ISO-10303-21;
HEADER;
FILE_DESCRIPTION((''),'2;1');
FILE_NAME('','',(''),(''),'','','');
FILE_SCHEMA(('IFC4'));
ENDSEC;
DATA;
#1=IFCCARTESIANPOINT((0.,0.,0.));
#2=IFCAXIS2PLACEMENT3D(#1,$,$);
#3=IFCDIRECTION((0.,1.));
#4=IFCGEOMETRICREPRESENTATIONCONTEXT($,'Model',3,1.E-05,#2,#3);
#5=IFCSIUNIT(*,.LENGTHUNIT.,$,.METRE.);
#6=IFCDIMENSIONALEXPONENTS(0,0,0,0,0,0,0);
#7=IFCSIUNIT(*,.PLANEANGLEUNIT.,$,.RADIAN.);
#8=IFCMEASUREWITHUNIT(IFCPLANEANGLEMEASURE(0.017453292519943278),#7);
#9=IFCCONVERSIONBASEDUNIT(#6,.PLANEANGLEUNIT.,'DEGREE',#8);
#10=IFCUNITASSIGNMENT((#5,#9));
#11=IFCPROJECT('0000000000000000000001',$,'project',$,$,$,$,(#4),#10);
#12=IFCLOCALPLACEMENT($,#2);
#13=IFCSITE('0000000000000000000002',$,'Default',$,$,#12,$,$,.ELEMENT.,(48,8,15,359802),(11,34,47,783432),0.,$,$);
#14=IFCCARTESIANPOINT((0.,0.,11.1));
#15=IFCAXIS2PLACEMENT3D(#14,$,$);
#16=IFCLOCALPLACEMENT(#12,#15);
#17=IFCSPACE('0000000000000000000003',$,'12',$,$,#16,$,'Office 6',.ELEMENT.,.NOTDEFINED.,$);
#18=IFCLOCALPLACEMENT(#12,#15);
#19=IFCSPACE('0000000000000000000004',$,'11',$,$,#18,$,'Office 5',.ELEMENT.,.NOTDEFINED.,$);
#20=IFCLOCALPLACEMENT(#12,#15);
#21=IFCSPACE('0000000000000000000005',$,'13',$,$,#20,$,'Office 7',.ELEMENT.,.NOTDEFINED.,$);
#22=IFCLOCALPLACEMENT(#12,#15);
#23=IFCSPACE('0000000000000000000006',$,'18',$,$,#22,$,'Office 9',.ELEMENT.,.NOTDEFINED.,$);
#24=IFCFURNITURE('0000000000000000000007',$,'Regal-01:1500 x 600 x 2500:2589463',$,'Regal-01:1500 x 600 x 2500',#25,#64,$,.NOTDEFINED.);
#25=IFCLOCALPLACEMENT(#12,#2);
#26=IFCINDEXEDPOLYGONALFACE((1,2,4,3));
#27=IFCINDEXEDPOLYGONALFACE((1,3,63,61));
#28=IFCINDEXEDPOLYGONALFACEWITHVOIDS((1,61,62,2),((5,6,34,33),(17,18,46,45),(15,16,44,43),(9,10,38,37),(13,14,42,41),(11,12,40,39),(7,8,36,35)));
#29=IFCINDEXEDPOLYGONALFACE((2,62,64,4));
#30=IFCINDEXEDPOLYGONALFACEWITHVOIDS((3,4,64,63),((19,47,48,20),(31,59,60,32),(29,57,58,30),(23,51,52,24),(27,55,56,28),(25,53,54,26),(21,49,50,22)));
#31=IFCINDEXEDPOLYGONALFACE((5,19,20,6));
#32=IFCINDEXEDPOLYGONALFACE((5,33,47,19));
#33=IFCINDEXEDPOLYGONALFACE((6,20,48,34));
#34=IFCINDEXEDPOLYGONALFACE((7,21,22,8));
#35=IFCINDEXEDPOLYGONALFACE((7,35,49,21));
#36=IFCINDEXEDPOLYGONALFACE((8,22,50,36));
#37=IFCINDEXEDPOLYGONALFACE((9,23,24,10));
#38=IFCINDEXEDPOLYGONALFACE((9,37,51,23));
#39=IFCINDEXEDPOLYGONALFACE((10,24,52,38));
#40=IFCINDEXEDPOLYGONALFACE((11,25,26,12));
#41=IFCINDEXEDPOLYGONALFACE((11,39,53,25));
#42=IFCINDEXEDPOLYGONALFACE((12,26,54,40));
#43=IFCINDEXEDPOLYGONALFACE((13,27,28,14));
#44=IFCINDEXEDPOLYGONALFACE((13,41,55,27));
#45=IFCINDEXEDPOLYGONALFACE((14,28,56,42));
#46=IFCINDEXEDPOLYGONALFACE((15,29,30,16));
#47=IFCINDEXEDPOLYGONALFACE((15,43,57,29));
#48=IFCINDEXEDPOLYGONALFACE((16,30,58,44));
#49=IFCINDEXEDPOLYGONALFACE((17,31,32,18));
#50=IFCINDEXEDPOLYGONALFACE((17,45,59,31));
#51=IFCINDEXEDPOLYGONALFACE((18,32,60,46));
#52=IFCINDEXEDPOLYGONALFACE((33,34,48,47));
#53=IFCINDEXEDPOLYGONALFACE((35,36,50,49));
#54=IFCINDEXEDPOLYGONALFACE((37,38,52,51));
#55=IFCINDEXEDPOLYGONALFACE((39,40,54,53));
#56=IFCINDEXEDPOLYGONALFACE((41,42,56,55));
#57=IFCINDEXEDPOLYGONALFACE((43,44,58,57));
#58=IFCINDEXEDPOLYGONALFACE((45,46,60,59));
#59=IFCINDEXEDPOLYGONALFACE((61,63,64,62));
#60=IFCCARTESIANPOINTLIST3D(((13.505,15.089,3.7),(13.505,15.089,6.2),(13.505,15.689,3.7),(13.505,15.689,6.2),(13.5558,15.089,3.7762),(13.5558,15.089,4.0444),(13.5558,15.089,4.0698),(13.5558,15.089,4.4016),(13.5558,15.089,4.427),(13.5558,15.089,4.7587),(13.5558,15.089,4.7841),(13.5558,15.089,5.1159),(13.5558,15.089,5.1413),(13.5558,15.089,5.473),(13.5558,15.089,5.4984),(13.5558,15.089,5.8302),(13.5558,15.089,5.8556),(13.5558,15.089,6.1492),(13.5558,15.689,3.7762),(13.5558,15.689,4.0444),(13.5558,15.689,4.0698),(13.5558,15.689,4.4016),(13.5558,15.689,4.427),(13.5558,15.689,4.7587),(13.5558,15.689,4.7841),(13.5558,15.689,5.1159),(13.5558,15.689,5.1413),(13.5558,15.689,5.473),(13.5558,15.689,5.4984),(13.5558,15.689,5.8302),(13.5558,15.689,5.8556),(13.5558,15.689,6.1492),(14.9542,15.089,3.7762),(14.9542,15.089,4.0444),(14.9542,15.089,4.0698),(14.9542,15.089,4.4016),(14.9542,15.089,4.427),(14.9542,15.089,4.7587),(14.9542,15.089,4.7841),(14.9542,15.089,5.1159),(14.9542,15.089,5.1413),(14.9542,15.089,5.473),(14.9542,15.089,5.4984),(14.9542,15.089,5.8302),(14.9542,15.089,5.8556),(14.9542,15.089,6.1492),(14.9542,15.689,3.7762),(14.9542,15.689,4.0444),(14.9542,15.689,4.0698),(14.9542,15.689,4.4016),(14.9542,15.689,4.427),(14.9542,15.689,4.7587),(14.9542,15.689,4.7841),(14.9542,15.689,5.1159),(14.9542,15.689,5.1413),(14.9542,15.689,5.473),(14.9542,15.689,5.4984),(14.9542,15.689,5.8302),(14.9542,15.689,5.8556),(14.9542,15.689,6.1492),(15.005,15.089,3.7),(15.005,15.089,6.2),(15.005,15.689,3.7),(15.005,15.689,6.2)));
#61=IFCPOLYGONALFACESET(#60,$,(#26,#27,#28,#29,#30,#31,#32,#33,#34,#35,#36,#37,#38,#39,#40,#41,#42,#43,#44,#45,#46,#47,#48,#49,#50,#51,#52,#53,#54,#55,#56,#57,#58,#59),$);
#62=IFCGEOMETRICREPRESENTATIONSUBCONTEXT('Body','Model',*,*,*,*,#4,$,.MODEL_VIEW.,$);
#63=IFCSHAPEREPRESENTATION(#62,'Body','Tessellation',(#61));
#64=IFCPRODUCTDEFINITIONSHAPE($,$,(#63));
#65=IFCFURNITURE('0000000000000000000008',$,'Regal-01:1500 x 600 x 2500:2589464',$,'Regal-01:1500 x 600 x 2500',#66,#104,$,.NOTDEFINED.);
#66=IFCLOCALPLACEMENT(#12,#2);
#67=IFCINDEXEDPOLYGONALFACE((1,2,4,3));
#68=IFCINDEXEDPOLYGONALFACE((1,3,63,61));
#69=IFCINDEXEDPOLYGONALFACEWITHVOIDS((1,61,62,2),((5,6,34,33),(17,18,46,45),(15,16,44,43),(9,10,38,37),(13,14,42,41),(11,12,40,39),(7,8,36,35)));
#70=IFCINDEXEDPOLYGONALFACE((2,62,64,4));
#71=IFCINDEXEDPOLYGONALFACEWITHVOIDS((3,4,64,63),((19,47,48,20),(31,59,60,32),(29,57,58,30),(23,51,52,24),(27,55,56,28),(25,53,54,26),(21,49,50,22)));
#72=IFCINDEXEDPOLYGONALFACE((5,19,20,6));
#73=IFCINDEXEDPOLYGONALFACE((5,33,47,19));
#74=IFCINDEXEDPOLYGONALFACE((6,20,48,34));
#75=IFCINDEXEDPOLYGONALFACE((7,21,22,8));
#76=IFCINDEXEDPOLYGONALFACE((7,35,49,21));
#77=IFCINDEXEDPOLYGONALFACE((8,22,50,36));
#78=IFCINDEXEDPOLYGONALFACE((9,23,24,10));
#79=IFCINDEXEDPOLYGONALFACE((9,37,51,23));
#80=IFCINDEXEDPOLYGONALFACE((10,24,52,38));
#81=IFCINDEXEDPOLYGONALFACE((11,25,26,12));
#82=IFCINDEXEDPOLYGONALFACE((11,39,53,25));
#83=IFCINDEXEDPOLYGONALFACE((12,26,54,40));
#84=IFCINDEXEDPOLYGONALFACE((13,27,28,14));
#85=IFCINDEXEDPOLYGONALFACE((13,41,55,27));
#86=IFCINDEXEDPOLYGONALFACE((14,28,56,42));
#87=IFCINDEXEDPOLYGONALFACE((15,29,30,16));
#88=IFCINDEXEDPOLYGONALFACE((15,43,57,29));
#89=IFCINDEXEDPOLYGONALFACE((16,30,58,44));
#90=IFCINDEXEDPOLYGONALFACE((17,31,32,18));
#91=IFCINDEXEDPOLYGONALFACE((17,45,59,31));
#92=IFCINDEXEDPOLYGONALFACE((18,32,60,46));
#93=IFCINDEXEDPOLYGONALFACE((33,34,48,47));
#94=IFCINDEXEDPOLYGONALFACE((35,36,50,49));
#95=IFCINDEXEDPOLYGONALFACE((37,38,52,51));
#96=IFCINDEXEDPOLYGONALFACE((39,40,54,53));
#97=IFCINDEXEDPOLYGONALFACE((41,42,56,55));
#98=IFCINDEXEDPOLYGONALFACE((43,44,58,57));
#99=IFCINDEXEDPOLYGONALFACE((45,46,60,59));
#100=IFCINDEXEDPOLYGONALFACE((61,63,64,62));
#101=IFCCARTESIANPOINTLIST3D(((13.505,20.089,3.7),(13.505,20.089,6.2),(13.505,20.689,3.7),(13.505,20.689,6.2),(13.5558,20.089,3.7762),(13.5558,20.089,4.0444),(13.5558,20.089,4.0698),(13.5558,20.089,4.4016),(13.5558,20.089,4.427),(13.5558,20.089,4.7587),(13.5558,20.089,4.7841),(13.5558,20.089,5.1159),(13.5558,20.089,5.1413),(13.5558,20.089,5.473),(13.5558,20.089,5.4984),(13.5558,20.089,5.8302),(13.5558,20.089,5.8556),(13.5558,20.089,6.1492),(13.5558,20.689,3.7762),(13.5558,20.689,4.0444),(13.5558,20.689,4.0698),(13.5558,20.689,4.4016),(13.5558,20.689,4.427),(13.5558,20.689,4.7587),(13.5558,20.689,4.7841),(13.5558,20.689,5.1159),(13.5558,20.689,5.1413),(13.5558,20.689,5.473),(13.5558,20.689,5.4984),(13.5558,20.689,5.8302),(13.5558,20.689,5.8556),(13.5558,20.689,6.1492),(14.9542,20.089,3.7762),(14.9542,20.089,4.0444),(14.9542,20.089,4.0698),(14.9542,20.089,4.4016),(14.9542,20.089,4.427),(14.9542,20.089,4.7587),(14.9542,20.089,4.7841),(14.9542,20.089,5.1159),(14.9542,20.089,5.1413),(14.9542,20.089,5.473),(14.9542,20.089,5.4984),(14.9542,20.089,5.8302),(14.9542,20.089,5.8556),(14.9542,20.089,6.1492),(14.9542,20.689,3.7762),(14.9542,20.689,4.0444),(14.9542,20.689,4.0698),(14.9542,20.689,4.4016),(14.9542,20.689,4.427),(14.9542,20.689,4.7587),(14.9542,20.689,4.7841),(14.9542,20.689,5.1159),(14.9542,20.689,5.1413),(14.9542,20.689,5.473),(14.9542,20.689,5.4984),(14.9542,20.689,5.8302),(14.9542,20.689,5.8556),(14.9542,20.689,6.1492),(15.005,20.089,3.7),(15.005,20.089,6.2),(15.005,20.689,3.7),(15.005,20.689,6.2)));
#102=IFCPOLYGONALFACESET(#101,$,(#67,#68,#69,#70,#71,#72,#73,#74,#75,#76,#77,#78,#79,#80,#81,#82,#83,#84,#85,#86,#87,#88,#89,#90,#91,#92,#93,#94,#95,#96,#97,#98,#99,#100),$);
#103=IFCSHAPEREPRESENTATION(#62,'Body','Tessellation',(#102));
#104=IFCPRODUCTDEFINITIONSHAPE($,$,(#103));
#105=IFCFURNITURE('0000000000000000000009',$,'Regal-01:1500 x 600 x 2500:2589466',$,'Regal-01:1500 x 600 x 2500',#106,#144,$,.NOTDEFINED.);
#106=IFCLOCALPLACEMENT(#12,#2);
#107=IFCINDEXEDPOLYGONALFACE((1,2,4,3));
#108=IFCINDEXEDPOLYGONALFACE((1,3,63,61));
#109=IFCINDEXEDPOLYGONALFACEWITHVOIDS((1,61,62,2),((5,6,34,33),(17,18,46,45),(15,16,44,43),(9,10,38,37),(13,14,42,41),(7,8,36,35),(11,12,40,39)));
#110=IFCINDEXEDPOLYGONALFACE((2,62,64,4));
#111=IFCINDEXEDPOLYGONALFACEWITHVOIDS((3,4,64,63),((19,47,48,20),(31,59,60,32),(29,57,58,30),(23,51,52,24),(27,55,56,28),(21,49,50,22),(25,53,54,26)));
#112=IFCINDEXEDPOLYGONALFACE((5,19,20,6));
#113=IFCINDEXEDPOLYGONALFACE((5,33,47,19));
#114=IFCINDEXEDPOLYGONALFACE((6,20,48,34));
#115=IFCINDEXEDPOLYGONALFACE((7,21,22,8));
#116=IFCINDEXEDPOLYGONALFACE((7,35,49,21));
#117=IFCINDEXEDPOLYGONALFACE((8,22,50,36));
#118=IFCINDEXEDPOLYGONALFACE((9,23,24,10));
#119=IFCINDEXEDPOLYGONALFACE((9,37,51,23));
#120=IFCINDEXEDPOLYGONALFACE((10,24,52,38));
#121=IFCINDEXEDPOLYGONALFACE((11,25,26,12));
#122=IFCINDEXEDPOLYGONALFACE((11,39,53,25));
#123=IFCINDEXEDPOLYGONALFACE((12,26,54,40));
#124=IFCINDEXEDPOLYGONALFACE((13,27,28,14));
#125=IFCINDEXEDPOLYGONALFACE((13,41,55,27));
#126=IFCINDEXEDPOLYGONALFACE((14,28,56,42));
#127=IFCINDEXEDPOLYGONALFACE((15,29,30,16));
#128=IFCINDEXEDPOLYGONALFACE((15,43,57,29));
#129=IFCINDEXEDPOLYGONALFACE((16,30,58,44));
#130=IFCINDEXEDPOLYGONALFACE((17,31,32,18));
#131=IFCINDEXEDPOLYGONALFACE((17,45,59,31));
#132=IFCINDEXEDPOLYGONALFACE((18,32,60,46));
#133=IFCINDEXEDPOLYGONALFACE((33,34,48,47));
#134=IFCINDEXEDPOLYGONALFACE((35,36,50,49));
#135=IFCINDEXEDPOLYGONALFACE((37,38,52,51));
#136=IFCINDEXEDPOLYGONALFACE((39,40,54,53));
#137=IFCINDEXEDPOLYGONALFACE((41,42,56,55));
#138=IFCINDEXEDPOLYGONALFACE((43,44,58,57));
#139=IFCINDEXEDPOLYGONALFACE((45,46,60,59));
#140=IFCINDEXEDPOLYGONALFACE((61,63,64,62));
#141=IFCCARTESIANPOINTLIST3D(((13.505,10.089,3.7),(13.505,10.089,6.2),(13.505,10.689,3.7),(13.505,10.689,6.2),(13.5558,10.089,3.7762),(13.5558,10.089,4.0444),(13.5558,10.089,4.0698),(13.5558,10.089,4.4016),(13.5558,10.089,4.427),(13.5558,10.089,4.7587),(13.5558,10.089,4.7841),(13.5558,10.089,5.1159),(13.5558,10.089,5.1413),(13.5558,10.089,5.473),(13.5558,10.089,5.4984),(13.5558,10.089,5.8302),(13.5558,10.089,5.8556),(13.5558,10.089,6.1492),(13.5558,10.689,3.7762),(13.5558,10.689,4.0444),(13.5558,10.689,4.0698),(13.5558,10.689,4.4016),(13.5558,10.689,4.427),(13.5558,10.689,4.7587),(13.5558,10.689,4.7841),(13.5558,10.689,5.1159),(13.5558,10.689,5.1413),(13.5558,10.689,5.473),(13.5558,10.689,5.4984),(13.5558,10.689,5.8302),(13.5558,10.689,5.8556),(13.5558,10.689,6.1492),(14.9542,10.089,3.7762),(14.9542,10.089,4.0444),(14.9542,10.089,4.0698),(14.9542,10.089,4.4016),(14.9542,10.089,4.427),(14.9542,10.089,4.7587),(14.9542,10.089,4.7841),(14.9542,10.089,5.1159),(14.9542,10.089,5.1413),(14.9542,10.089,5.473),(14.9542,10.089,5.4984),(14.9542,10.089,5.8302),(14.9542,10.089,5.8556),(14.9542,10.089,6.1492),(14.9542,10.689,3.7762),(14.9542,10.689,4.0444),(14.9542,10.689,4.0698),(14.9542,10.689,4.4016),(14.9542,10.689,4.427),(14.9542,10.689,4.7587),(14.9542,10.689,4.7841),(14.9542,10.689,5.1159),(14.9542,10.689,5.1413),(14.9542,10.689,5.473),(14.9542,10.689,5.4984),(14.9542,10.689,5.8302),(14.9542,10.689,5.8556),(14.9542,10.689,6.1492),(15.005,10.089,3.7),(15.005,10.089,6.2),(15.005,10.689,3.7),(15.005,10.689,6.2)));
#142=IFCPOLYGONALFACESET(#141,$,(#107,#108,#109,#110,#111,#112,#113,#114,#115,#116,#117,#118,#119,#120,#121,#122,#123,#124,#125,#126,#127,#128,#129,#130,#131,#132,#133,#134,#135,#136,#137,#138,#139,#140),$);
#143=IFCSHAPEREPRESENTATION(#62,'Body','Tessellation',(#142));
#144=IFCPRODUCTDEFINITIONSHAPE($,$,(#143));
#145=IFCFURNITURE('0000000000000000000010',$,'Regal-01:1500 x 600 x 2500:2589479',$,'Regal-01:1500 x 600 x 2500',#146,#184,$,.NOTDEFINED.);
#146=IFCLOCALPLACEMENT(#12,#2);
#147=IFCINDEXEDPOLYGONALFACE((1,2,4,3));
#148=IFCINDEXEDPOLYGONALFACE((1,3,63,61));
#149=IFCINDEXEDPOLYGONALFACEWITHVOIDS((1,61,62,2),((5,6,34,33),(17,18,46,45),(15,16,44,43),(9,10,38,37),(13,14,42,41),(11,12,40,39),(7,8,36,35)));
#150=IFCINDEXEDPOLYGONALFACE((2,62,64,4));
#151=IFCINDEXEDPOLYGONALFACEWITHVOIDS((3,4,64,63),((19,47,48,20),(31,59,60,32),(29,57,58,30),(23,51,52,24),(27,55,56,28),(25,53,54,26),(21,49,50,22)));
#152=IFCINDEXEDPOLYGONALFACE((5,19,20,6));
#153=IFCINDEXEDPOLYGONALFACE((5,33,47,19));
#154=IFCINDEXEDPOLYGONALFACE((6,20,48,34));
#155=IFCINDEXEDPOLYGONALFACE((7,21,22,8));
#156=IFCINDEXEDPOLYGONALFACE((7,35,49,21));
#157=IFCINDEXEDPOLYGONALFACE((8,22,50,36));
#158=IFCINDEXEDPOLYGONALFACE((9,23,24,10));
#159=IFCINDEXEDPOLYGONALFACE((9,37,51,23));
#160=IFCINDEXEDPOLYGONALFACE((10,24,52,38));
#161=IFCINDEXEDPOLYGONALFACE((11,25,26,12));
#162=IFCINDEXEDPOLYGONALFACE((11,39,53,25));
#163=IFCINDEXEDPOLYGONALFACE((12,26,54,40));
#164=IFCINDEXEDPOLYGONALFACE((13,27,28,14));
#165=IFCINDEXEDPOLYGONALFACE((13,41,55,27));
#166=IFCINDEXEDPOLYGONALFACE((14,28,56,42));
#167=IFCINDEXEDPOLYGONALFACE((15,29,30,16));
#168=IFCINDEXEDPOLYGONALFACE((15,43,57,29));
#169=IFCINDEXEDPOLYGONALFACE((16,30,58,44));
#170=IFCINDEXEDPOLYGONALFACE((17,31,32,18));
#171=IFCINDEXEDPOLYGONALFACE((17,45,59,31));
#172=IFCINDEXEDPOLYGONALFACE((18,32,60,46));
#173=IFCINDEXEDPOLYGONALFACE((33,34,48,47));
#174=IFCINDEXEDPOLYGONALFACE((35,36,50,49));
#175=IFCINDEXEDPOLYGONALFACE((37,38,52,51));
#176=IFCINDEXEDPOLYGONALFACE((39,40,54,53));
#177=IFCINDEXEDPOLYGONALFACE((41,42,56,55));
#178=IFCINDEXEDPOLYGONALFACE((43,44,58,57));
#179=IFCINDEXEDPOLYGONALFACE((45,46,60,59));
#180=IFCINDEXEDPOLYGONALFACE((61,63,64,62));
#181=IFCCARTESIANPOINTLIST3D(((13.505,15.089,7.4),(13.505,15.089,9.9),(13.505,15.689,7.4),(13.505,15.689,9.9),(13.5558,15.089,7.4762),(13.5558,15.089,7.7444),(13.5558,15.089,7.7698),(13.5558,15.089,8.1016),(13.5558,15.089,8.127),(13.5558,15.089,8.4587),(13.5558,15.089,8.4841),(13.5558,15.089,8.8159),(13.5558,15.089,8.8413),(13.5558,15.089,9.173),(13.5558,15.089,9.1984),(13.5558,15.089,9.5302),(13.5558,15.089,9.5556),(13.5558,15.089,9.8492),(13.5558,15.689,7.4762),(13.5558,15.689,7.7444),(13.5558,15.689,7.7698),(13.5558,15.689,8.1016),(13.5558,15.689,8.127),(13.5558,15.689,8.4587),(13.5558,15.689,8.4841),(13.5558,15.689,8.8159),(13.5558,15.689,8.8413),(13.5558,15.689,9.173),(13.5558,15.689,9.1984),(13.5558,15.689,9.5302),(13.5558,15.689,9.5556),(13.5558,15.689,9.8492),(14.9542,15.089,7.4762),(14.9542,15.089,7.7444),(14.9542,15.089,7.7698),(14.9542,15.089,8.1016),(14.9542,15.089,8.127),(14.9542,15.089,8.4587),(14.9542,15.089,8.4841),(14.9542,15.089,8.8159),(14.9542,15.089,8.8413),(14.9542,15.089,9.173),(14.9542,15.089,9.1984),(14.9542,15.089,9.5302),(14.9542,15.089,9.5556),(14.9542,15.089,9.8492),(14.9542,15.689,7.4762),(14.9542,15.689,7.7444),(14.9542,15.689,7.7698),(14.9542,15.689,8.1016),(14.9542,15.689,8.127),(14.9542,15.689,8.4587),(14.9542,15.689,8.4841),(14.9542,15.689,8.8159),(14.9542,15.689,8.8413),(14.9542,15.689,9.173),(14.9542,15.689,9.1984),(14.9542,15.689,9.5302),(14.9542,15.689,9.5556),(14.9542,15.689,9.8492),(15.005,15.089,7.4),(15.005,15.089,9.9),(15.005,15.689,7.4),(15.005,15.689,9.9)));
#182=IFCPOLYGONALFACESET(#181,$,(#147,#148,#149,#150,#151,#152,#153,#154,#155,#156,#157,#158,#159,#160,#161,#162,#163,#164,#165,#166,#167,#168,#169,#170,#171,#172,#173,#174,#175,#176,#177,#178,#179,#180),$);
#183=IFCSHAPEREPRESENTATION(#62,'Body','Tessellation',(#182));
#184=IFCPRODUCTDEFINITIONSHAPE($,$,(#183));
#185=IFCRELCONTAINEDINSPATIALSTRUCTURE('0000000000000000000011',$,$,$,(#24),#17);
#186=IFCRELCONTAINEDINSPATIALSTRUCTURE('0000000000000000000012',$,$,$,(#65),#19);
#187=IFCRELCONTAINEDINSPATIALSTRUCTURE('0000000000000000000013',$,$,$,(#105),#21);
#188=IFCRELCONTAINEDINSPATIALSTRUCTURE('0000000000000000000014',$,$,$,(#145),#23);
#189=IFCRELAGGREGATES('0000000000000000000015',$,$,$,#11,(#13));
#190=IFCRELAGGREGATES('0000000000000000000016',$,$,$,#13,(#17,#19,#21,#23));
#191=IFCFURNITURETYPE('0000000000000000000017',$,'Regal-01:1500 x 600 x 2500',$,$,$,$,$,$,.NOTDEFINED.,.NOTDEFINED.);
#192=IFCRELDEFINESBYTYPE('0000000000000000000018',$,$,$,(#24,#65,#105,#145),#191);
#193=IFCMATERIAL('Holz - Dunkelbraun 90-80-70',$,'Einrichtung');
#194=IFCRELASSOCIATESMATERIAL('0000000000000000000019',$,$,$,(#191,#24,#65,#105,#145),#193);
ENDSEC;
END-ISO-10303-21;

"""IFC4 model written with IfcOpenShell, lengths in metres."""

from ifc_helpers import new_model, entity, si_unit, converted_unit, direction, frame, origin, place, context, subcontext, project, spatial, indexed_curve, outline, extrude, source, transform, mapped, material, type_object, type_shapes, element, save


model = new_model("IFC4")

# Units and contexts
model_context = context("Model", 3, precision=1e-05, world=origin(), true_north=direction((0.0, 1.0)))
body_context = subcontext(model_context, "Body", "Model", "MODEL_VIEW")
ifc_project = project(units=[si_unit("LENGTHUNIT", "METRE"), converted_unit("PLANEANGLEUNIT", "DEGREE", entity("IfcPlaneAngleMeasure", 0.017453292519943278), si_unit("PLANEANGLEUNIT", "RADIAN"), dimensions=[0, 0, 0, 0, 0, 0, 0])], contexts=[model_context])

# Site
site_placement = place(None, origin())
site = spatial("IfcSite", under=ifc_project, at=site_placement, Name="Default", CompositionType="ELEMENT", RefLatitude=(48, 8, 15, 359802), RefLongitude=(11, 34, 47, 783432), RefElevation=0.0)

# Shared definitions
ifc_material = material(Name="Holz - Dunkelbraun 90-80-70", Category="Einrichtung")
furniture_type = type_object("IfcFurnitureType", Name="Regal-01:1500 x 600 x 2500", AssemblyPlace="NOTDEFINED", PredefinedType="NOTDEFINED", material=ifc_material)
shared_shape = source(origin(), body_context, "Body", "SweptSolid", [
    extrude(outline(indexed_curve([(-0.75, -1.25), (0.75, -1.25), (0.75, 1.25), (-0.75, 1.25), (-0.75, -1.25)], self_intersect=False), holes=[indexed_curve([(-0.6992, 1.1992), (0.6992, 1.1992), (0.6992, 0.9056), (-0.6992, 0.9056), (-0.6992, 1.1992)], self_intersect=False), indexed_curve([(-0.6992, -1.1738), (-0.6992, -0.9056), (0.6992, -0.9056), (0.6992, -1.1738), (-0.6992, -1.1738)], self_intersect=False), indexed_curve([(0.6992, 0.1913), (-0.6992, 0.1913), (-0.6992, 0.523), (0.6992, 0.523), (0.6992, 0.1913)], self_intersect=False), indexed_curve([(0.6992, -0.5484), (0.6992, -0.8802), (-0.6992, -0.8802), (-0.6992, -0.5484), (0.6992, -0.5484)], self_intersect=False), indexed_curve([(-0.6992, 0.8802), (0.6992, 0.8802), (0.6992, 0.5484), (-0.6992, 0.5484), (-0.6992, 0.8802)], self_intersect=False), indexed_curve([(-0.6992, 0.1659), (0.6992, 0.1659), (0.6992, -0.1659), (-0.6992, -0.1659), (-0.6992, 0.1659)], self_intersect=False), indexed_curve([(-0.6992, -0.1913), (0.6992, -0.1913), (0.6992, -0.523), (-0.6992, -0.523), (-0.6992, -0.1913)], self_intersect=False)]), frame((0.0, -0.6048, 1.25), z_axis=(0.0, 1.0, 0.0), x_axis=(-1.0, 0.0, 0.0)), (0.0, 0.0, 1.0), 0.6),
])
type_shapes(furniture_type, [shared_shape])

# Shared definitions
space_1_placement = place(site_placement, frame((0.0, 0.0, 11.1)))
space_1 = spatial("IfcSpace", under=site, at=space_1_placement, Name="12", LongName="Office 6", CompositionType="ELEMENT", PredefinedType="NOTDEFINED")

# Furniture
furniture_1_placement = place(space_1_placement, frame((14.255, 15.6938, -7.4)))
element("IfcFurniture", 1, at=furniture_1_placement, inside=space_1, type_object=furniture_type, material=ifc_material, Name="Regal-01:1500 x 600 x 2500:2589463", ObjectType="Regal-01:1500 x 600 x 2500", PredefinedType="NOTDEFINED", context=body_context, shape_type="MappedRepresentation", body=[
    mapped(shared_shape, transform((0.0, 0.0, 0.0), scale=1.0)),
])

# Shared definitions
space_2_placement = place(site_placement, frame((0.0, 0.0, 11.1)))
space_2 = spatial("IfcSpace", under=site, at=space_2_placement, Name="11", LongName="Office 5", CompositionType="ELEMENT", PredefinedType="NOTDEFINED")

# Furniture
furniture_2_placement = place(space_2_placement, frame((14.255, 20.6938, -7.4)))
element("IfcFurniture", 2, at=furniture_2_placement, inside=space_2, type_object=furniture_type, material=ifc_material, Name="Regal-01:1500 x 600 x 2500:2589464", ObjectType="Regal-01:1500 x 600 x 2500", PredefinedType="NOTDEFINED", context=body_context, shape_type="MappedRepresentation", body=[
    mapped(shared_shape, transform((0.0, 0.0, 0.0), scale=1.0)),
])

# Shared definitions
space_3_placement = place(site_placement, frame((0.0, 0.0, 11.1)))
space_3 = spatial("IfcSpace", under=site, at=space_3_placement, Name="13", LongName="Office 7", CompositionType="ELEMENT", PredefinedType="NOTDEFINED")

# Furniture
furniture_3_placement = place(space_3_placement, frame((14.255, 10.6938, -7.4)))
element("IfcFurniture", 3, at=furniture_3_placement, inside=space_3, type_object=furniture_type, material=ifc_material, Name="Regal-01:1500 x 600 x 2500:2589466", ObjectType="Regal-01:1500 x 600 x 2500", PredefinedType="NOTDEFINED", context=body_context, shape_type="MappedRepresentation", body=[
    mapped(shared_shape, transform((0.0, 0.0, 0.0), scale=1.0)),
])

# Shared definitions
space_4_placement = place(site_placement, frame((0.0, 0.0, 11.1)))
space_4 = spatial("IfcSpace", under=site, at=space_4_placement, Name="18", LongName="Office 9", CompositionType="ELEMENT", PredefinedType="NOTDEFINED")

# Furniture
furniture_4_placement = place(space_4_placement, frame((14.255, 15.6938, -3.7)))
element("IfcFurniture", 4, at=furniture_4_placement, inside=space_4, type_object=furniture_type, material=ifc_material, Name="Regal-01:1500 x 600 x 2500:2589479", ObjectType="Regal-01:1500 x 600 x 2500", PredefinedType="NOTDEFINED", context=body_context, shape_type="MappedRepresentation", body=[
    mapped(shared_shape, transform((0.0, 0.0, 0.0), scale=1.0)),
])

save(model, "model.ifc")
